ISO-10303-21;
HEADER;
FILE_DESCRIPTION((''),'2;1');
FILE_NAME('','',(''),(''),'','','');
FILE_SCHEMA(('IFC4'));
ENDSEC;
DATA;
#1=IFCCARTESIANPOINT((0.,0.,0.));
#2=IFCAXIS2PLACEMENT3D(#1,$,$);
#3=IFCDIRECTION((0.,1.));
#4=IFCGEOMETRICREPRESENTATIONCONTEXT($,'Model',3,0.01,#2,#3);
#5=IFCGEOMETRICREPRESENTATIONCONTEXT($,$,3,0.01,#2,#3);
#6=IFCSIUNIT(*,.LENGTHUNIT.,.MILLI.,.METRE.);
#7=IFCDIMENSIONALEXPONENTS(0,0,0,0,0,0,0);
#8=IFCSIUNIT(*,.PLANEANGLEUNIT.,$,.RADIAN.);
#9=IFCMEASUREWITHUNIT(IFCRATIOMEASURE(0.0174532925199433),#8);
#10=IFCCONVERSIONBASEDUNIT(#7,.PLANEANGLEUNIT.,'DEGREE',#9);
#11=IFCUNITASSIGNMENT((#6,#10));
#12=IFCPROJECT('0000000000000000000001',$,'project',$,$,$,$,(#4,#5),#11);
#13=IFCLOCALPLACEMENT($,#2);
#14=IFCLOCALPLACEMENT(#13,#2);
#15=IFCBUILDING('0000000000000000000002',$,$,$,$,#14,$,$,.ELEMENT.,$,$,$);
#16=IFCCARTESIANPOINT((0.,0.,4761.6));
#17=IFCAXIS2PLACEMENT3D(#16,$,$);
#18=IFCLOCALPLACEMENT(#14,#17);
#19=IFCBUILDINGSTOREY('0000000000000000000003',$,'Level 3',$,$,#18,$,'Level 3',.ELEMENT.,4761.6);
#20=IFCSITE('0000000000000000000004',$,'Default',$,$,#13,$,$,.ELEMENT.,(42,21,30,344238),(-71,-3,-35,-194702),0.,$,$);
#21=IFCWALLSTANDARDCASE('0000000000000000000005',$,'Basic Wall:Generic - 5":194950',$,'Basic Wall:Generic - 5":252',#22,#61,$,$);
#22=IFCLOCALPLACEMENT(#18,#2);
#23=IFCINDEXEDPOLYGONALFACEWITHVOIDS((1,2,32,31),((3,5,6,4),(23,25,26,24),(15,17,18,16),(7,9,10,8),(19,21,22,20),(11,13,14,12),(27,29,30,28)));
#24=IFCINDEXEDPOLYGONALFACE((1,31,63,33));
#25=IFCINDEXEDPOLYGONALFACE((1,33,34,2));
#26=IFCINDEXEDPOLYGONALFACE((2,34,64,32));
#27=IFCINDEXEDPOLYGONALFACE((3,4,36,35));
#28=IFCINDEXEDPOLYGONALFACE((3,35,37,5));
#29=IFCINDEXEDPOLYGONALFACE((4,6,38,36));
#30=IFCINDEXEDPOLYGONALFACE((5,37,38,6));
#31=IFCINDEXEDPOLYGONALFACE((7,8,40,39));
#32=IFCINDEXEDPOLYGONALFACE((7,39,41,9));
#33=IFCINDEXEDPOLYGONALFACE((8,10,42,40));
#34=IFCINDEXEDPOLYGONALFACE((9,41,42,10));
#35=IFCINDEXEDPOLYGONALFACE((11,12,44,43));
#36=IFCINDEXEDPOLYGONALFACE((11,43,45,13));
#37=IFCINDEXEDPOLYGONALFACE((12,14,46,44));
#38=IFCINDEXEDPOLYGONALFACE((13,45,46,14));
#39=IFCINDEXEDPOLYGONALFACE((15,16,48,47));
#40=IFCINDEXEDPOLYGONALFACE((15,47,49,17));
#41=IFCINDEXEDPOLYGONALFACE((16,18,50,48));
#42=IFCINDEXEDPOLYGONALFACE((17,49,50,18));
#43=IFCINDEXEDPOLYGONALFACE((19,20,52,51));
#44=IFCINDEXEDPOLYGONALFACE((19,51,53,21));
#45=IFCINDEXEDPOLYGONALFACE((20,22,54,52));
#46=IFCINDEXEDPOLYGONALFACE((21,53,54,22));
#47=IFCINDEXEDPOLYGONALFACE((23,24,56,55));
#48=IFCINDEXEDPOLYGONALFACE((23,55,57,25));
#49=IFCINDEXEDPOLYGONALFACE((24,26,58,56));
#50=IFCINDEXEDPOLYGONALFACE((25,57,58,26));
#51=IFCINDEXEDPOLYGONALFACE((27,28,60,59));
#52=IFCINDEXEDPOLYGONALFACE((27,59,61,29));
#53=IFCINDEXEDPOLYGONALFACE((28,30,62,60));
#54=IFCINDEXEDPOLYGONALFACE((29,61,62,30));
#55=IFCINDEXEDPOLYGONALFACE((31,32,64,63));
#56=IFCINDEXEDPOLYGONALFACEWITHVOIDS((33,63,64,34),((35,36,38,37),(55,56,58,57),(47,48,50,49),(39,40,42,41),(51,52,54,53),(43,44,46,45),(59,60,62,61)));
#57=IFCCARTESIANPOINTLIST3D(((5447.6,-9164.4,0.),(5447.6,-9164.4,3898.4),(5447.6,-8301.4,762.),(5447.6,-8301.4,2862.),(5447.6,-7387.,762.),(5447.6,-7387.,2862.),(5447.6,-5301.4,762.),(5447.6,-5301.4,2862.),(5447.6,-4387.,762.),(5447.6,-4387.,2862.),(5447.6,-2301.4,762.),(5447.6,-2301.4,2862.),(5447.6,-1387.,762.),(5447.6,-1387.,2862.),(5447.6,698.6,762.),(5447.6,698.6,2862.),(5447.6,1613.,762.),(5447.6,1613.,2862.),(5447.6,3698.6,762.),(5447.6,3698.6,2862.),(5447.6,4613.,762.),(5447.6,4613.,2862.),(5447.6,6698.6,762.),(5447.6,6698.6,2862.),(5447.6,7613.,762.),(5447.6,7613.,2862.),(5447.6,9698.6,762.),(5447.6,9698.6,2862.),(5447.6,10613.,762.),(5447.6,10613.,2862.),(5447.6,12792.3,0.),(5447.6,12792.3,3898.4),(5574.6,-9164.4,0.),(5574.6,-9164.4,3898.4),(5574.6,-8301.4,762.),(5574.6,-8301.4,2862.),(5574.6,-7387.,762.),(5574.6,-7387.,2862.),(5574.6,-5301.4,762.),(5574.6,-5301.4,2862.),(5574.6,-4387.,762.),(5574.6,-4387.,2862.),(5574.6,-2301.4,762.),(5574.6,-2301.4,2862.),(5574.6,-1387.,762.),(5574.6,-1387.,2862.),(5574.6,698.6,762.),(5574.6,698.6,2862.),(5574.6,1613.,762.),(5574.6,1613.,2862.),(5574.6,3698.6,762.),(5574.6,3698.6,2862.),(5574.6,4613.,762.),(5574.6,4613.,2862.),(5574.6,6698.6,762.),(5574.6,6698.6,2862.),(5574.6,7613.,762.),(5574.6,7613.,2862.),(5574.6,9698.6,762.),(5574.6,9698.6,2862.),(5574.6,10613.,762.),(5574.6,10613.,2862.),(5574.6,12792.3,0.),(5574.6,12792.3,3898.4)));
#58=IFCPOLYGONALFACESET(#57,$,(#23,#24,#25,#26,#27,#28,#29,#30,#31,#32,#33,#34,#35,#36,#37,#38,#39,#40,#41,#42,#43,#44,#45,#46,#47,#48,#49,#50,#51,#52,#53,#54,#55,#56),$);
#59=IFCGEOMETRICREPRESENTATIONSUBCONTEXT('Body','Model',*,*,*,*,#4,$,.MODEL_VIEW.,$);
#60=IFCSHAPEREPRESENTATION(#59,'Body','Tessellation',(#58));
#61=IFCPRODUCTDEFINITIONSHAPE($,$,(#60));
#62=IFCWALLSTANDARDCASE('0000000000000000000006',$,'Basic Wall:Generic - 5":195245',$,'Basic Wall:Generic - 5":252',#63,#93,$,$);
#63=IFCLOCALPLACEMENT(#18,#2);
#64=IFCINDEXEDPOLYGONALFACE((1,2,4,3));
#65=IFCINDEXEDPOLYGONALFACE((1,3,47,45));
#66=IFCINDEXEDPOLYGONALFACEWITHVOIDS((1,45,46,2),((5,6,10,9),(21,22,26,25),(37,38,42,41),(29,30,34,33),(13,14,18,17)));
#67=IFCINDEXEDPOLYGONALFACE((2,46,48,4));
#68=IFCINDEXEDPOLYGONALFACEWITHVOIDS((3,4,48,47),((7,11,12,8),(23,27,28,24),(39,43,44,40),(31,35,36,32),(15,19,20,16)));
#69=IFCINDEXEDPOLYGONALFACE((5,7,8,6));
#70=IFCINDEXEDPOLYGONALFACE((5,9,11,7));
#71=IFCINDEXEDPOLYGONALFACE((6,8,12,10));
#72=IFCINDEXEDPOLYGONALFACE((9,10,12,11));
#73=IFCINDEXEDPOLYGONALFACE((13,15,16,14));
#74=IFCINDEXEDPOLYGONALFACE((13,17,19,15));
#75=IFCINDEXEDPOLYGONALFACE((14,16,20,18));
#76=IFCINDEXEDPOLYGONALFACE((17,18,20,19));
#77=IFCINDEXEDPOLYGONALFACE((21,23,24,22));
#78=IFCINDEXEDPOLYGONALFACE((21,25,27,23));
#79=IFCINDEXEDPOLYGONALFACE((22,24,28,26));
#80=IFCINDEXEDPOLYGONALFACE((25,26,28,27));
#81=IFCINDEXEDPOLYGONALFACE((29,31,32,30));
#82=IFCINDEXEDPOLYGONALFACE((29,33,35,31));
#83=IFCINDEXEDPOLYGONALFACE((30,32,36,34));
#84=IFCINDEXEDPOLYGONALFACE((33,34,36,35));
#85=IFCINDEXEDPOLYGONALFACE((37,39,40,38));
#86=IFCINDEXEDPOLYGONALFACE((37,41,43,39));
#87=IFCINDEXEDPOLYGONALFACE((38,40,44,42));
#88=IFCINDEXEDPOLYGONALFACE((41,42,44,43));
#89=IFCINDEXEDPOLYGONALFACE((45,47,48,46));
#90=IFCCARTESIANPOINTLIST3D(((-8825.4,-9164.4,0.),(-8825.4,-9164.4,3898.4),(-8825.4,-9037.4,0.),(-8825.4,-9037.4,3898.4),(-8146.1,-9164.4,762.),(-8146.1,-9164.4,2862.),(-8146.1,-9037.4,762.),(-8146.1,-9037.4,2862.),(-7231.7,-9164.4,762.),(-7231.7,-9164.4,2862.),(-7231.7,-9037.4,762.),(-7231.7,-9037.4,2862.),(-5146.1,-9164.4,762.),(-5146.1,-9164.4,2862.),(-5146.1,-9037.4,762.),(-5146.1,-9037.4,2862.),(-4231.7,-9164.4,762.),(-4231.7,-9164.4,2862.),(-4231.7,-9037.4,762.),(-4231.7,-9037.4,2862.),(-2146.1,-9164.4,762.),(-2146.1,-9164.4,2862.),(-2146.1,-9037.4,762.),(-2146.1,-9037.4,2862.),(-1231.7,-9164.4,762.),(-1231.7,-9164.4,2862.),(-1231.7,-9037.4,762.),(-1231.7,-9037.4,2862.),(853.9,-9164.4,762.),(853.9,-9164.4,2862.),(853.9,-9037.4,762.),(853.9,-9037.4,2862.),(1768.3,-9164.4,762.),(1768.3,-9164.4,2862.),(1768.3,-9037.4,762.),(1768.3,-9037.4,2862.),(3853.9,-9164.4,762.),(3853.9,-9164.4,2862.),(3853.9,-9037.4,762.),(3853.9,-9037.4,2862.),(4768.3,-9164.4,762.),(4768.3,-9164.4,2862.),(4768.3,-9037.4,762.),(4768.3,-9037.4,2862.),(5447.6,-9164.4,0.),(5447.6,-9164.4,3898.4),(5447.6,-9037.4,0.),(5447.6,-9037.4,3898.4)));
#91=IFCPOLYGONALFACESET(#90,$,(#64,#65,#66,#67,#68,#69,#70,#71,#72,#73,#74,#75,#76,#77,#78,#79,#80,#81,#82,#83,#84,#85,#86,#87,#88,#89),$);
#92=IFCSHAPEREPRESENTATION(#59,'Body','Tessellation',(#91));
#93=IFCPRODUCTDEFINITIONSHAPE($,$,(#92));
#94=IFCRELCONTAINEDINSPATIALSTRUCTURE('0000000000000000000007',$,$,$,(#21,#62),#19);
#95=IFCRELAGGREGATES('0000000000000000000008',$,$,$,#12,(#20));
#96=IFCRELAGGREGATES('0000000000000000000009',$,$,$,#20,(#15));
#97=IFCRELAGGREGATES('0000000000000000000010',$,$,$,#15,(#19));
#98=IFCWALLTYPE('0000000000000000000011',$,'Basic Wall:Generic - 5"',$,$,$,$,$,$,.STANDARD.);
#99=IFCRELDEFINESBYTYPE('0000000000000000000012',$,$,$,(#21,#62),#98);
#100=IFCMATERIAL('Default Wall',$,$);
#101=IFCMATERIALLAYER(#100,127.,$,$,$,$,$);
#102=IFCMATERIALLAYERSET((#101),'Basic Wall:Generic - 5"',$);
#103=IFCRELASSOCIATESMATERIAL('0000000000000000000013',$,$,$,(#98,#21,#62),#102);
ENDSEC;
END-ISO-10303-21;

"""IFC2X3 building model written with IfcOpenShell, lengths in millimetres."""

from ifc_helpers import new_model, entity, si_unit, converted_unit, direction, frame, frame_2d, origin, place, context, subcontext, project, spatial, polyline, rectangle, extrude, clip, bounded_halfspace, material, layer, layer_set, layer_usage, type_object, element, save


model = new_model("IFC2X3")

# Units and contexts
model_context = context("Model", 3, precision=0.01, world=origin(), true_north=direction((0.0, 1.0)))
context_of_model = context(None, 3, precision=0.01, world=origin(), true_north=direction((0.0, 1.0)))
body_context = subcontext(model_context, "Body", "Model", "MODEL_VIEW")
ifc_project = project(units=[si_unit("LENGTHUNIT", "METRE", prefix="MILLI"), converted_unit("PLANEANGLEUNIT", "DEGREE", entity("IfcRatioMeasure", 0.0174532925199433), si_unit("PLANEANGLEUNIT", "RADIAN"), dimensions=[0, 0, 0, 0, 0, 0, 0])], contexts=[model_context, context_of_model])

# Site, building, storey
site_placement = place(None, origin())
site = spatial("IfcSite", under=ifc_project, at=site_placement, Name="Default", CompositionType="ELEMENT", RefLatitude=(42, 21, 30, 344238), RefLongitude=(-71, -3, -35, -194702), RefElevation=0.0)
building_placement = place(site_placement, origin())
building = spatial("IfcBuilding", under=site, at=building_placement, CompositionType="ELEMENT")
storey_placement = place(building_placement, frame((0.0, 0.0, 4761.6)))
storey = spatial("IfcBuildingStorey", under=building, at=storey_placement, Name="Level 3", LongName="Level 3", CompositionType="ELEMENT", Elevation=4761.6)

# Walls, openings
ifc_material_1 = material(Name="Default Wall")
ifc_layer_1 = layer(ifc_material_1, 127.0)
ifc_layer_set_1 = layer_set([ifc_layer_1], Name="Basic Wall:Generic - 5\"")
wall_type = type_object("IfcWallType", Name="Basic Wall:Generic - 5\"", PredefinedType="STANDARD", material=ifc_layer_set_1)
ifc_layer_usage_1 = layer_usage(ifc_layer_set_1, "AXIS2", "NEGATIVE", 63.5)
wall_1_placement = place(storey_placement, frame((5511.1, 12792.3, 0.0), z_axis=(0.0, 0.0, 1.0), x_axis=(0.0, -1.0, 0.0)))
wall_1 = element("IfcWallStandardCase", 1, at=wall_1_placement, inside=storey, type_object=wall_type, material=ifc_layer_usage_1, Name="Basic Wall:Generic - 5\":194950", ObjectType="Basic Wall:Generic - 5\":252", context=body_context, shape_type="Clipping", body=[
    clip(extrude(rectangle(XDim=21956.7, YDim=127.0, at=frame_2d((10978.4, 0.0), x_axis=(-1.0, 0.0))), origin(), (0.0, 0.0, 1.0), 3898.4), bounded_halfspace(frame((0.0, -63.5, 3898.4), z_axis=(0.0, 0.0, -1.0), x_axis=(1.0, 0.0, 0.0)), True, frame((0.0, -63.5, 3898.4)), polyline([(0.0, 0.0), (21829.7, 0.0), (21956.7, 0.0), (21956.7, 127.0), (0.0, 127.0), (0.0, 0.0)]))),
])
opening_1_placement = place(wall_1_placement, frame((2179.3, -63.5, 762.0)))
element("IfcOpeningElement", 2, at=opening_1_placement, cuts=wall_1, ObjectType="Opening", context=body_context, shape_type="SweptSolid", body=[
    extrude(rectangle(XDim=2100.0, YDim=914.4, at=frame_2d((1050.0, 457.2), x_axis=(-1.0, 0.0))), frame((0.0, 0.0, 0.0), z_axis=(0.0, 1.0, 0.0), x_axis=(0.0, 0.0, 1.0)), (0.0, 0.0, 1.0), 127.0),
])
opening_2_placement = place(wall_1_placement, frame((5179.3, -63.5, 762.0)))
element("IfcOpeningElement", 3, at=opening_2_placement, cuts=wall_1, ObjectType="Opening", context=body_context, shape_type="SweptSolid", body=[
    extrude(rectangle(XDim=2100.0, YDim=914.4, at=frame_2d((1050.0, 457.2), x_axis=(-1.0, 0.0))), frame((0.0, 0.0, 0.0), z_axis=(0.0, 1.0, 0.0), x_axis=(0.0, 0.0, 1.0)), (0.0, 0.0, 1.0), 127.0),
])
opening_3_placement = place(wall_1_placement, frame((8179.3, -63.5, 762.0)))
element("IfcOpeningElement", 4, at=opening_3_placement, cuts=wall_1, ObjectType="Opening", context=body_context, shape_type="SweptSolid", body=[
    extrude(rectangle(XDim=2100.0, YDim=914.4, at=frame_2d((1050.0, 457.2), x_axis=(-1.0, 0.0))), frame((0.0, 0.0, 0.0), z_axis=(0.0, 1.0, 0.0), x_axis=(0.0, 0.0, 1.0)), (0.0, 0.0, 1.0), 127.0),
])
opening_4_placement = place(wall_1_placement, frame((11179.3, -63.5, 762.0)))
element("IfcOpeningElement", 5, at=opening_4_placement, cuts=wall_1, ObjectType="Opening", context=body_context, shape_type="SweptSolid", body=[
    extrude(rectangle(XDim=2100.0, YDim=914.4, at=frame_2d((1050.0, 457.2), x_axis=(-1.0, 0.0))), frame((0.0, 0.0, 0.0), z_axis=(0.0, 1.0, 0.0), x_axis=(0.0, 0.0, 1.0)), (0.0, 0.0, 1.0), 127.0),
])
opening_5_placement = place(wall_1_placement, frame((14179.3, -63.5, 762.0)))
element("IfcOpeningElement", 6, at=opening_5_placement, cuts=wall_1, ObjectType="Opening", context=body_context, shape_type="SweptSolid", body=[
    extrude(rectangle(XDim=2100.0, YDim=914.4, at=frame_2d((1050.0, 457.2), x_axis=(-1.0, 0.0))), frame((0.0, 0.0, 0.0), z_axis=(0.0, 1.0, 0.0), x_axis=(0.0, 0.0, 1.0)), (0.0, 0.0, 1.0), 127.0),
])
opening_6_placement = place(wall_1_placement, frame((17179.3, -63.5, 762.0)))
element("IfcOpeningElement", 7, at=opening_6_placement, cuts=wall_1, ObjectType="Opening", context=body_context, shape_type="SweptSolid", body=[
    extrude(rectangle(XDim=2100.0, YDim=914.4, at=frame_2d((1050.0, 457.2), x_axis=(-1.0, 0.0))), frame((0.0, 0.0, 0.0), z_axis=(0.0, 1.0, 0.0), x_axis=(0.0, 0.0, 1.0)), (0.0, 0.0, 1.0), 127.0),
])
opening_7_placement = place(wall_1_placement, frame((20179.3, -63.5, 762.0)))
element("IfcOpeningElement", 8, at=opening_7_placement, cuts=wall_1, ObjectType="Opening", context=body_context, shape_type="SweptSolid", body=[
    extrude(rectangle(XDim=2100.0, YDim=914.4, at=frame_2d((1050.0, 457.2), x_axis=(-1.0, 0.0))), frame((0.0, 0.0, 0.0), z_axis=(0.0, 1.0, 0.0), x_axis=(0.0, 0.0, 1.0)), (0.0, 0.0, 1.0), 127.0),
])
ifc_layer_usage_2 = layer_usage(ifc_layer_set_1, "AXIS2", "NEGATIVE", 63.5)
wall_2_placement = place(storey_placement, frame((5447.6, -9100.9, 0.0), z_axis=(0.0, 0.0, 1.0), x_axis=(-1.0, 0.0, 0.0)))
wall_2 = element("IfcWallStandardCase", 9, at=wall_2_placement, inside=storey, type_object=wall_type, material=ifc_layer_usage_2, Name="Basic Wall:Generic - 5\":195245", ObjectType="Basic Wall:Generic - 5\":252", context=body_context, shape_type="Clipping", body=[
    clip(extrude(rectangle(XDim=14273.0, YDim=127.0, at=frame_2d((7136.5, 0.0), x_axis=(-1.0, 0.0))), origin(), (0.0, 0.0, 1.0), 3898.4), bounded_halfspace(frame((0.0, -63.5, 3898.4), z_axis=(0.0, 0.0, -1.0), x_axis=(0.0, 1.0, 0.0)), True, frame((0.0, -63.5, 3898.4)), polyline([(0.0, 0.0), (14273.0, 0.0), (14273.0, 127.0), (0.0, 127.0), (0.0, 0.0)]))),
])
opening_8_placement = place(wall_2_placement, frame((13593.7, 63.5, 762.0)))
element("IfcOpeningElement", 10, at=opening_8_placement, cuts=wall_2, ObjectType="Opening", context=body_context, shape_type="SweptSolid", body=[
    extrude(rectangle(XDim=2100.0, YDim=914.4, at=frame_2d((1050.0, 457.2), x_axis=(-1.0, 0.0))), frame((0.0, 0.0, 0.0), z_axis=(0.0, -1.0, 0.0), x_axis=(0.0, 0.0, 1.0)), (0.0, 0.0, 1.0), 127.0),
])
opening_9_placement = place(wall_2_placement, frame((10593.7, 63.5, 762.0)))
element("IfcOpeningElement", 11, at=opening_9_placement, cuts=wall_2, ObjectType="Opening", context=body_context, shape_type="SweptSolid", body=[
    extrude(rectangle(XDim=2100.0, YDim=914.4, at=frame_2d((1050.0, 457.2), x_axis=(-1.0, 0.0))), frame((0.0, 0.0, 0.0), z_axis=(0.0, -1.0, 0.0), x_axis=(0.0, 0.0, 1.0)), (0.0, 0.0, 1.0), 127.0),
])
opening_10_placement = place(wall_2_placement, frame((7593.7, 63.5, 762.0)))
element("IfcOpeningElement", 12, at=opening_10_placement, cuts=wall_2, ObjectType="Opening", context=body_context, shape_type="SweptSolid", body=[
    extrude(rectangle(XDim=2100.0, YDim=914.4, at=frame_2d((1050.0, 457.2), x_axis=(-1.0, 0.0))), frame((0.0, 0.0, 0.0), z_axis=(0.0, -1.0, 0.0), x_axis=(0.0, 0.0, 1.0)), (0.0, 0.0, 1.0), 127.0),
])
opening_11_placement = place(wall_2_placement, frame((4593.7, 63.5, 762.0)))
element("IfcOpeningElement", 13, at=opening_11_placement, cuts=wall_2, ObjectType="Opening", context=body_context, shape_type="SweptSolid", body=[
    extrude(rectangle(XDim=2100.0, YDim=914.4, at=frame_2d((1050.0, 457.2), x_axis=(-1.0, 0.0))), frame((0.0, 0.0, 0.0), z_axis=(0.0, -1.0, 0.0), x_axis=(0.0, 0.0, 1.0)), (0.0, 0.0, 1.0), 127.0),
])
opening_12_placement = place(wall_2_placement, frame((1593.7, 63.5, 762.0)))
element("IfcOpeningElement", 14, at=opening_12_placement, cuts=wall_2, ObjectType="Opening", context=body_context, shape_type="SweptSolid", body=[
    extrude(rectangle(XDim=2100.0, YDim=914.4, at=frame_2d((1050.0, 457.2), x_axis=(-1.0, 0.0))), frame((0.0, 0.0, 0.0), z_axis=(0.0, -1.0, 0.0), x_axis=(0.0, 0.0, 1.0)), (0.0, 0.0, 1.0), 127.0),
])

save(model, "model.ifc")
